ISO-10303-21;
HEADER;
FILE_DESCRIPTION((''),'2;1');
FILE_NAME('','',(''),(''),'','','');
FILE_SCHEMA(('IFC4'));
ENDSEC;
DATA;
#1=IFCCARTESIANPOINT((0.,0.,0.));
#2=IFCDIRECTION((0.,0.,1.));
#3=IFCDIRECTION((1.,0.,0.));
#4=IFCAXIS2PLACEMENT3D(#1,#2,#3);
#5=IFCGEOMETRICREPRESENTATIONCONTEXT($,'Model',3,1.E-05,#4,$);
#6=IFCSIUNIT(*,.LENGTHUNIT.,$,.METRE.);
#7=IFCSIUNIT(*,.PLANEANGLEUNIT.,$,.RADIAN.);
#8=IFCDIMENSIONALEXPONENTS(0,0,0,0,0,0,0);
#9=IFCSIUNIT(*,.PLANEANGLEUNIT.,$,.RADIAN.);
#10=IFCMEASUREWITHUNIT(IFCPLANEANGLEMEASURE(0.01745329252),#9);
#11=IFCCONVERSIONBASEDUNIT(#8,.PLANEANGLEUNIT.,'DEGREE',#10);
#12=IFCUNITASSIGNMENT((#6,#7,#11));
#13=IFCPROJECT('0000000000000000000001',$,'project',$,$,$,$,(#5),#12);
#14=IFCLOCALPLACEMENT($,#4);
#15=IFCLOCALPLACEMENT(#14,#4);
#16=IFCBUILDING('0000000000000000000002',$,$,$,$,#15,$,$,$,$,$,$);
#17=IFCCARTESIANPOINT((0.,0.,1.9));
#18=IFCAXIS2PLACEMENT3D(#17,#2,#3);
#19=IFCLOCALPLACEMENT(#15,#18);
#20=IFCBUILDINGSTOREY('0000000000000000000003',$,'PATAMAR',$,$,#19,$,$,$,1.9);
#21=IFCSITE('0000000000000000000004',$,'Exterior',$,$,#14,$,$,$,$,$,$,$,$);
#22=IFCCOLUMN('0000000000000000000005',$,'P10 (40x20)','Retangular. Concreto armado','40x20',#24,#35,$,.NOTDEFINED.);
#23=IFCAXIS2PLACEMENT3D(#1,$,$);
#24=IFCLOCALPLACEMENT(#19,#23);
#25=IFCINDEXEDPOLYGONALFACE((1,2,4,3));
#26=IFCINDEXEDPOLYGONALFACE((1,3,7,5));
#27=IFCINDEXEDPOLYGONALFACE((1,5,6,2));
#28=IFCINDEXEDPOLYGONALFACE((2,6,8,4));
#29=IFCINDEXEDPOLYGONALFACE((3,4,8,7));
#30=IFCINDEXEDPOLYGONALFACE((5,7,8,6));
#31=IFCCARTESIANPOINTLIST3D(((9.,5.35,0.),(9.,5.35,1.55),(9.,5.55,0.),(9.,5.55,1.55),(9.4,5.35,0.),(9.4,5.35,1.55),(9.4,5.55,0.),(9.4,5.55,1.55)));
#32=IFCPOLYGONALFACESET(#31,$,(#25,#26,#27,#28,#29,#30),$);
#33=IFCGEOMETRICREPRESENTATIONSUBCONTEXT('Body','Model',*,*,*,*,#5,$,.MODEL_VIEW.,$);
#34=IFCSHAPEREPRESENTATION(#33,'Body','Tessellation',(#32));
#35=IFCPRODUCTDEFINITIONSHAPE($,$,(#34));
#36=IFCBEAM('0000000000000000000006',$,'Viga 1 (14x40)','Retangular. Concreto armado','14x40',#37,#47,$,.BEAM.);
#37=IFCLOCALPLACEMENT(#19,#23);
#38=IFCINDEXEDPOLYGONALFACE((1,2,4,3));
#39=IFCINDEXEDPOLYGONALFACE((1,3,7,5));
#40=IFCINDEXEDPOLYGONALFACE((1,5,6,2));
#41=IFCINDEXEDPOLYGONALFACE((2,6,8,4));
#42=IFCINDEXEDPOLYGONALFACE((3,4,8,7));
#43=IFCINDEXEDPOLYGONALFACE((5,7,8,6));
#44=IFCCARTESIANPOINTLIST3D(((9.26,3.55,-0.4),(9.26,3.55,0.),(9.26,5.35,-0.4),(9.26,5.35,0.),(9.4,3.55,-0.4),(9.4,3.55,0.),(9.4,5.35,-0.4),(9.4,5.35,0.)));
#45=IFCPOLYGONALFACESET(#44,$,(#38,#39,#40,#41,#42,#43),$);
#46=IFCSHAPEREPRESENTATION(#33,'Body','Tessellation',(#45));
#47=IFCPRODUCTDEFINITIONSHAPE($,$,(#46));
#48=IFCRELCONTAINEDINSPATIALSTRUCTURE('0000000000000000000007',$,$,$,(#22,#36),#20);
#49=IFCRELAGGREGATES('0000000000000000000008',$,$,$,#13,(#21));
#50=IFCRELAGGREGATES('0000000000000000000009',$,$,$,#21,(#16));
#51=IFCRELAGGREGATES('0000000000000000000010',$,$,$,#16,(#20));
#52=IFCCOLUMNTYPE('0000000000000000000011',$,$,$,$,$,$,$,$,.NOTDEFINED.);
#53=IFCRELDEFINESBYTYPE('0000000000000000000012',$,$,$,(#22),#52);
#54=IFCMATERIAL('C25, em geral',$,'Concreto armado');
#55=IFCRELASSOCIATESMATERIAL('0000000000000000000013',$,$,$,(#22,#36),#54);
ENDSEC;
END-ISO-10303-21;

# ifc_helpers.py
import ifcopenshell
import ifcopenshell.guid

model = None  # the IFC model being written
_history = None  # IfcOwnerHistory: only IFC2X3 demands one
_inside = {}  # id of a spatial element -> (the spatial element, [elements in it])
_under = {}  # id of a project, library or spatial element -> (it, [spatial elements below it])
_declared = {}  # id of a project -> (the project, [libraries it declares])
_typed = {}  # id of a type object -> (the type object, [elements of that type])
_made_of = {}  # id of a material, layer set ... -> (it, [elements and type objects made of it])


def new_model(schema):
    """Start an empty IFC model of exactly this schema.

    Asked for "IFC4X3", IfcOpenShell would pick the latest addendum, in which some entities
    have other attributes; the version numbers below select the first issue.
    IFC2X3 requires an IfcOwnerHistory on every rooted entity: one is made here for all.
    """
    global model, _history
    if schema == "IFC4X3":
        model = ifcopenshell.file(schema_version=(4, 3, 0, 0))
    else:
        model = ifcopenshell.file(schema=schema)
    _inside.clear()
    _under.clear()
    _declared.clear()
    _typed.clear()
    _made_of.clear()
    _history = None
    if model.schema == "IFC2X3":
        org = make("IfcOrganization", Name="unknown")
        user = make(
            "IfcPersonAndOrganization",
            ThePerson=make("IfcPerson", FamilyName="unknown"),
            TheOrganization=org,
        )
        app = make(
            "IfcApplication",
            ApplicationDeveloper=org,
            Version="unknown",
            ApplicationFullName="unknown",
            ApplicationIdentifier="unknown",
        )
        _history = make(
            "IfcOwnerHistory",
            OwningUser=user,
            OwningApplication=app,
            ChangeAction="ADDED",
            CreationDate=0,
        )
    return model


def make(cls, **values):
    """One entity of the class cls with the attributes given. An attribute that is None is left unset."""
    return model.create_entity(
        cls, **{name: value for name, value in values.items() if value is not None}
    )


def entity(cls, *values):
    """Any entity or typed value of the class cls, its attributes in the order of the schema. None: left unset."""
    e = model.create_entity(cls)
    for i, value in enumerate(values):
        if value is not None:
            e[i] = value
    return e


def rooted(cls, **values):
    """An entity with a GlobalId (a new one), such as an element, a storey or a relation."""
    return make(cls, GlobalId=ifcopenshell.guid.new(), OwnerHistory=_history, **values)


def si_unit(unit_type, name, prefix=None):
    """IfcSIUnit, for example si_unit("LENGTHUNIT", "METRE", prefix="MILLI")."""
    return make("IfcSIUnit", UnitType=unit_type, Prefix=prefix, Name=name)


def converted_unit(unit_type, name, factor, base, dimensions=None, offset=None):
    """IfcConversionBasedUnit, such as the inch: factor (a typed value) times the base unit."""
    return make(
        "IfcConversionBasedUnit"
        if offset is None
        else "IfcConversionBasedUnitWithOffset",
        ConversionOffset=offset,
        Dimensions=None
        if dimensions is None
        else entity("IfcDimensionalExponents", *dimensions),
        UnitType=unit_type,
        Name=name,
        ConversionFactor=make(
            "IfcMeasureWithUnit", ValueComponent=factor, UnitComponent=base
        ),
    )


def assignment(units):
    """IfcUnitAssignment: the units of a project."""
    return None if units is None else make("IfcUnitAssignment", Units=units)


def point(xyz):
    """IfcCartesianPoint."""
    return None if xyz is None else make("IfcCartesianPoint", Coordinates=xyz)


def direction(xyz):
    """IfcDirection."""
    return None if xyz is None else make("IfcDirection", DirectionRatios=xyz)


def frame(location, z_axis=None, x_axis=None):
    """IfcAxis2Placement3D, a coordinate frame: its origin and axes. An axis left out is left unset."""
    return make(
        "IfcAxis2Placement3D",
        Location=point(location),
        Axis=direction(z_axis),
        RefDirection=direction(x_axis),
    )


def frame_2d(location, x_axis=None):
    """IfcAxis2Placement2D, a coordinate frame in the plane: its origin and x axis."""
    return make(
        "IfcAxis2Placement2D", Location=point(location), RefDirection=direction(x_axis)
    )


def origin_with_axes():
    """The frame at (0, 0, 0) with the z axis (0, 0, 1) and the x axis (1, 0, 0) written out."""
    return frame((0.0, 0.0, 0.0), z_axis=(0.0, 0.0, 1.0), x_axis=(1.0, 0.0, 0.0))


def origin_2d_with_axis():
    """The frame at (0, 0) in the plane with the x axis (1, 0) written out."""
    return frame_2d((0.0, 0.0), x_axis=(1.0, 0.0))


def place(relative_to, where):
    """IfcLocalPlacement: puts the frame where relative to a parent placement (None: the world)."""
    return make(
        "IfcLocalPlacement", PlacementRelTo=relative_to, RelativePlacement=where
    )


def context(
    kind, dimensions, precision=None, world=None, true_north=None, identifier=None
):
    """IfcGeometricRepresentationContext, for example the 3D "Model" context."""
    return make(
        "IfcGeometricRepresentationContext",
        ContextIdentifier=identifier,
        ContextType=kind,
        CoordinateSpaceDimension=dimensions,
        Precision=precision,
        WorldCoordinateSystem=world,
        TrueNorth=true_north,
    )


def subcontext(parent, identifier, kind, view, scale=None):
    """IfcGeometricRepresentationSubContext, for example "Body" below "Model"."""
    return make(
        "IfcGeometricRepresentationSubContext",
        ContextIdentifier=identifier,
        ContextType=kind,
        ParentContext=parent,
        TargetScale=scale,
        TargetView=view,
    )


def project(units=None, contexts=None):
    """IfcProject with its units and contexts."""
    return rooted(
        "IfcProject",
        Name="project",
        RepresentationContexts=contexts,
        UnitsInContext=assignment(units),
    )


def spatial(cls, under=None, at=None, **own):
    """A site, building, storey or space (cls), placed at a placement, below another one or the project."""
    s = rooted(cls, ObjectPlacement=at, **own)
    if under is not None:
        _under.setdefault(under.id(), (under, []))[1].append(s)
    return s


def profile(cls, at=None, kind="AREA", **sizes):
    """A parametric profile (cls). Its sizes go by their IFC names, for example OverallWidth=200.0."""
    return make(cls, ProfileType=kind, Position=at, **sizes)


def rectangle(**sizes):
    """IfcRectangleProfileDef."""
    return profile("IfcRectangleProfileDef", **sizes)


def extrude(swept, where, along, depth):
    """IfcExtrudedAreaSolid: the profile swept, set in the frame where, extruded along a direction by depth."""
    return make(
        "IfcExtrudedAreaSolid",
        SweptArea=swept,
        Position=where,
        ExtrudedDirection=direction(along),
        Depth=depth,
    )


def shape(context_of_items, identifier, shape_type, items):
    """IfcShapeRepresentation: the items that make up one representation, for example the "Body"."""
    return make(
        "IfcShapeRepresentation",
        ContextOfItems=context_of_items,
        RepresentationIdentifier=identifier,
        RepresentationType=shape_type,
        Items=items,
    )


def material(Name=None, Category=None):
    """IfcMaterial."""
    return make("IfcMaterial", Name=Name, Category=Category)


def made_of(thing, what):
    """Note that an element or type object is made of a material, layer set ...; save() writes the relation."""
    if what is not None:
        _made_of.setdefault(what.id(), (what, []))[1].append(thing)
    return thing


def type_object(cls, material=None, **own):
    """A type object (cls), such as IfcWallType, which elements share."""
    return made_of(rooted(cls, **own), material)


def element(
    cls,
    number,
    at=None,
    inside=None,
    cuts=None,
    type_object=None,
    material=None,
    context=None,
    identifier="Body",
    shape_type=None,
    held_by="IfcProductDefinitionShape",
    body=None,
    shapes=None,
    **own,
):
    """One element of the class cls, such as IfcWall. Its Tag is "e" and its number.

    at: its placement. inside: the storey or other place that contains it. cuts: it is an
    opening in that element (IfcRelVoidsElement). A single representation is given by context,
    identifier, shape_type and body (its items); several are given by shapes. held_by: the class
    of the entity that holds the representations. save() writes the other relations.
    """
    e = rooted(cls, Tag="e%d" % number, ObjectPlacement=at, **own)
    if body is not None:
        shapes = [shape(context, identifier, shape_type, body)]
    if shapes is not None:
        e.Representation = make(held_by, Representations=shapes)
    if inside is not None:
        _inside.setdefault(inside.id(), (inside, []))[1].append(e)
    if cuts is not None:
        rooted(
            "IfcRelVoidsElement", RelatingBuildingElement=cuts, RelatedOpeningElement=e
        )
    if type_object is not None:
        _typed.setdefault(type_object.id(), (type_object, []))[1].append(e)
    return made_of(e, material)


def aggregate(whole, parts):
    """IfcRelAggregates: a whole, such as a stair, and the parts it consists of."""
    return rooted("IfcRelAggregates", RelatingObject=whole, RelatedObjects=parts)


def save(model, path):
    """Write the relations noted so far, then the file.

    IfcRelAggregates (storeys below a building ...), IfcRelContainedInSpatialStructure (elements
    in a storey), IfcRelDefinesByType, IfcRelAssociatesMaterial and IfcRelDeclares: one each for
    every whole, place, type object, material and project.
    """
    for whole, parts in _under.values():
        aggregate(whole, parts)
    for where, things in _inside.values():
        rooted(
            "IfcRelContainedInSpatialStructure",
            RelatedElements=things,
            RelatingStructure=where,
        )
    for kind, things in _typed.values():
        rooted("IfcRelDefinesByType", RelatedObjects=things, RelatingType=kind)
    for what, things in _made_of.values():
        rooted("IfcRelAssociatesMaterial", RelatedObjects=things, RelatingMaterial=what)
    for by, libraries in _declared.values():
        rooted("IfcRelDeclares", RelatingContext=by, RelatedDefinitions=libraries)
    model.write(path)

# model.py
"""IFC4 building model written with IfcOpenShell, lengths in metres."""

from ifc_helpers import new_model, entity, si_unit, converted_unit, frame, frame_2d, origin_with_axes, origin_2d_with_axis, place, context, subcontext, project, spatial, rectangle, extrude, material, type_object, element, save


model = new_model("IFC4")

# Units and contexts
model_context = context("Model", 3, precision=1e-05, world=origin_with_axes())
body_context = subcontext(model_context, "Body", "Model", "MODEL_VIEW")
ifc_project = project(units=[si_unit("LENGTHUNIT", "METRE"), si_unit("PLANEANGLEUNIT", "RADIAN"), converted_unit("PLANEANGLEUNIT", "DEGREE", entity("IfcPlaneAngleMeasure", 0.01745329252), si_unit("PLANEANGLEUNIT", "RADIAN"), dimensions=[0, 0, 0, 0, 0, 0, 0])], contexts=[model_context])

# Site, building, storey
site_placement = place(None, origin_with_axes())
site = spatial("IfcSite", under=ifc_project, at=site_placement, Name="Exterior")
building_placement = place(site_placement, origin_with_axes())
building = spatial("IfcBuilding", under=site, at=building_placement)
storey_placement = place(building_placement, frame((0.0, 0.0, 1.9), z_axis=(0.0, 0.0, 1.0), x_axis=(1.0, 0.0, 0.0)))
storey = spatial("IfcBuildingStorey", under=building, at=storey_placement, Name="PATAMAR", Elevation=1.9)

# Column
ifc_material = material(Name="C25, em geral", Category="Concreto armado")
column_type = type_object("IfcColumnType", PredefinedType="NOTDEFINED")
column_placement = place(storey_placement, frame((9.2, 5.45, 0.0), z_axis=(0.0, 0.0, 1.0), x_axis=(1.0, 0.0, 0.0)))
element("IfcColumn", 1, at=column_placement, inside=storey, type_object=column_type, material=ifc_material, Name="P10 (40x20)", Description="Retangular. Concreto armado", ObjectType="40x20", PredefinedType="NOTDEFINED", context=body_context, shape_type="SweptSolid", body=[
    extrude(rectangle(XDim=0.4, YDim=0.2, at=origin_2d_with_axis()), origin_with_axes(), (0.0, 0.0, 1.0), 1.55),
])

# Beam
beam_placement = place(storey_placement, frame((9.33, 5.35, 0.0), z_axis=(0.0, -1.0, 0.0), x_axis=(1.0, 0.0, 0.0)))
element("IfcBeam", 2, at=beam_placement, inside=storey, material=ifc_material, Name="Viga 1 (14x40)", Description="Retangular. Concreto armado", ObjectType="14x40", PredefinedType="BEAM", context=body_context, shape_type="SweptSolid", body=[
    extrude(rectangle(XDim=0.14, YDim=0.4, at=frame_2d((0.0, -0.2), x_axis=(1.0, 0.0))), origin_with_axes(), (0.0, 0.0, 1.0), 1.8),
])

save(model, "model.ifc")
